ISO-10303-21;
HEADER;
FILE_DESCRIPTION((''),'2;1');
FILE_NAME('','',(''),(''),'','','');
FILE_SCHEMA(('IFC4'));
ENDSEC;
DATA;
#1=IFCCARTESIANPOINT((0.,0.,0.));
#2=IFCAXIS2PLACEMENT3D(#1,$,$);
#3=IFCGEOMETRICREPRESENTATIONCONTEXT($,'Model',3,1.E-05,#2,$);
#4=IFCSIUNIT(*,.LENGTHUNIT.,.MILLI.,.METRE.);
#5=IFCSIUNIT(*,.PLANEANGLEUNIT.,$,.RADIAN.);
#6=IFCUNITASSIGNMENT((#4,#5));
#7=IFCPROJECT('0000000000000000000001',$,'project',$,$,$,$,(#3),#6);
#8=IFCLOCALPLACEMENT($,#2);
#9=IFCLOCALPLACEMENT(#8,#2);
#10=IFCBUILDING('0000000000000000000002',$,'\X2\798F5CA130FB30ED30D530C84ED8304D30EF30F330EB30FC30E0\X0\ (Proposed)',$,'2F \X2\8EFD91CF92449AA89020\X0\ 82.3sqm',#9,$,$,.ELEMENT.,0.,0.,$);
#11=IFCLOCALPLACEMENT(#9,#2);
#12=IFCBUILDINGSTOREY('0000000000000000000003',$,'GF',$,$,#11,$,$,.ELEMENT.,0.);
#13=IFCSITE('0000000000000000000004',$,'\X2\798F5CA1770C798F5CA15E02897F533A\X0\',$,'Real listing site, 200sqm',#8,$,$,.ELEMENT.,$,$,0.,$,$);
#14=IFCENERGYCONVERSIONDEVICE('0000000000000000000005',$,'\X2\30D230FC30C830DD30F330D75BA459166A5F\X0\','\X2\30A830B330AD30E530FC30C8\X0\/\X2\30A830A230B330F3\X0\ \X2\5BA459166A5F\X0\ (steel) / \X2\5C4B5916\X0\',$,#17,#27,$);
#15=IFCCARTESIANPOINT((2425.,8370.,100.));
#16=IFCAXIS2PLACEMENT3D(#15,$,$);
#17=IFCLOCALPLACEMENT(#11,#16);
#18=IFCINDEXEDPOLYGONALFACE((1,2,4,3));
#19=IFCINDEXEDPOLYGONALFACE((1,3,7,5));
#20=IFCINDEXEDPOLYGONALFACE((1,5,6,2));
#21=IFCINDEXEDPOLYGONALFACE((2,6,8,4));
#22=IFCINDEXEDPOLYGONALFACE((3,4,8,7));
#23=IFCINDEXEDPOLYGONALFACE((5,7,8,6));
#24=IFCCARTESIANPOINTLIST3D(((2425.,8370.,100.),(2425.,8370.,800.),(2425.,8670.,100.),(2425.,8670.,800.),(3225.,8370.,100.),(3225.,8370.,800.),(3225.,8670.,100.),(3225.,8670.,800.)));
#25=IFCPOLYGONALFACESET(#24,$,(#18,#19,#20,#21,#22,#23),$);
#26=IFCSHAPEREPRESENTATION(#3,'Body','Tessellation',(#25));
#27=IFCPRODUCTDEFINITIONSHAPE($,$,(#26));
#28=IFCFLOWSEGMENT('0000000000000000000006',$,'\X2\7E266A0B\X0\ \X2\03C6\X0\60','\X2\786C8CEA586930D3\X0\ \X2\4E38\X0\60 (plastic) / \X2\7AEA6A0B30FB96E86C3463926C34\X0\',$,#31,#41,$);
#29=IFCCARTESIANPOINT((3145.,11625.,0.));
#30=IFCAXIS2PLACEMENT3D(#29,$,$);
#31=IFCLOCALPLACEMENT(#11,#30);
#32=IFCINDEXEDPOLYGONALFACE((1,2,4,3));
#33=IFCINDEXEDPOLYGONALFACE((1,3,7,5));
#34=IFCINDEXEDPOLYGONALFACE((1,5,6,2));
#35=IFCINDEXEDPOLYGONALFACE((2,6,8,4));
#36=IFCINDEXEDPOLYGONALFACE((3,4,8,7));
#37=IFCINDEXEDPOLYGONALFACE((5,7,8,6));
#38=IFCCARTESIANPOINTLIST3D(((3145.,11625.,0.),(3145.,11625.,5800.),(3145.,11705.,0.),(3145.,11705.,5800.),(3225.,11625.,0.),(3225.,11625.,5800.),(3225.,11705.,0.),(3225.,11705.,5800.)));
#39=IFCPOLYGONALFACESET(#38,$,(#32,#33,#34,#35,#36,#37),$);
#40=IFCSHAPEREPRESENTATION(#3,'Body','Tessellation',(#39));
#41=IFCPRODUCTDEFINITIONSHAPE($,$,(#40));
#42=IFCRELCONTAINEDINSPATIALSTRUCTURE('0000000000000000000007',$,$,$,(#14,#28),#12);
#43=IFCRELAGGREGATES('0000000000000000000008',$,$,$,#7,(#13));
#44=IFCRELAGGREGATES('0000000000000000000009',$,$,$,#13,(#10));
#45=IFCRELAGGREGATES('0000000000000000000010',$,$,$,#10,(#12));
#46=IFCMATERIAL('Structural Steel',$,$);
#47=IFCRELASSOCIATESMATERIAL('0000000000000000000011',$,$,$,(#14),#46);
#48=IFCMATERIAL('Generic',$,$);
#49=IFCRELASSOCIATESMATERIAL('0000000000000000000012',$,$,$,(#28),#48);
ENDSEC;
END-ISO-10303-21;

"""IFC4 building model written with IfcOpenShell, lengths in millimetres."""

from ifc_helpers import new_model, si_unit, frame, frame_2d, origin, place, context, project, spatial, rectangle, extrude, material, element, save


model = new_model("IFC4")

# Units and contexts
model_context = context("Model", 3, precision=1e-05, world=origin())
ifc_project = project(units=[si_unit("LENGTHUNIT", "METRE", prefix="MILLI"), si_unit("PLANEANGLEUNIT", "RADIAN")], contexts=[model_context])

# Site, building, storey
site_placement = place(None, origin())
site = spatial("IfcSite", under=ifc_project, at=site_placement, Name="福岡県福岡市西区", ObjectType="Real listing site, 200sqm", CompositionType="ELEMENT", RefElevation=0.0)
building_placement = place(site_placement, origin())
building = spatial("IfcBuilding", under=site, at=building_placement, Name="福岡・ロフト付きワンルーム (Proposed)", ObjectType="2F 軽量鉄骨造 82.3sqm", CompositionType="ELEMENT", ElevationOfRefHeight=0.0, ElevationOfTerrain=0.0)
storey_placement = place(building_placement, origin())
storey = spatial("IfcBuildingStorey", under=building, at=storey_placement, Name="GF", CompositionType="ELEMENT", Elevation=0.0)

# Shared definitions
ifc_material_1 = material(Name="Generic")

# Energy conversion device
ifc_material_2 = material(Name="Structural Steel")
energy_conversion_device_placement = place(storey_placement, frame((2425.0, 8370.0, 100.0)))
element("IfcEnergyConversionDevice", 1, at=energy_conversion_device_placement, inside=storey, material=ifc_material_2, Name="ヒートポンプ室外機", Description="エコキュート/エアコン 室外機 (steel) / 屋外", context=model_context, shape_type="SweptSolid", body=[
    extrude(rectangle(XDim=800.0, YDim=300.0, at=frame_2d((400.0, 150.0))), frame((2425.0, 8370.0, 100.0)), (0.0, 0.0, 1.0), 700.0),
])

# Flow segment
flow_segment_placement = place(storey_placement, frame((3145.0, 11625.0, 0.0)))
element("IfcFlowSegment", 2, at=flow_segment_placement, inside=storey, material=ifc_material_1, Name="縦樋 φ60", Description="硬質塩ビ 丸60 (plastic) / 竪樋・雨水排水", context=model_context, shape_type="SweptSolid", body=[
    extrude(rectangle(XDim=80.0, YDim=80.0, at=frame_2d((40.0, 40.0))), frame((3145.0, 11625.0, 0.0)), (0.0, 0.0, 1.0), 5800.0),
])

save(model, "model.ifc")
